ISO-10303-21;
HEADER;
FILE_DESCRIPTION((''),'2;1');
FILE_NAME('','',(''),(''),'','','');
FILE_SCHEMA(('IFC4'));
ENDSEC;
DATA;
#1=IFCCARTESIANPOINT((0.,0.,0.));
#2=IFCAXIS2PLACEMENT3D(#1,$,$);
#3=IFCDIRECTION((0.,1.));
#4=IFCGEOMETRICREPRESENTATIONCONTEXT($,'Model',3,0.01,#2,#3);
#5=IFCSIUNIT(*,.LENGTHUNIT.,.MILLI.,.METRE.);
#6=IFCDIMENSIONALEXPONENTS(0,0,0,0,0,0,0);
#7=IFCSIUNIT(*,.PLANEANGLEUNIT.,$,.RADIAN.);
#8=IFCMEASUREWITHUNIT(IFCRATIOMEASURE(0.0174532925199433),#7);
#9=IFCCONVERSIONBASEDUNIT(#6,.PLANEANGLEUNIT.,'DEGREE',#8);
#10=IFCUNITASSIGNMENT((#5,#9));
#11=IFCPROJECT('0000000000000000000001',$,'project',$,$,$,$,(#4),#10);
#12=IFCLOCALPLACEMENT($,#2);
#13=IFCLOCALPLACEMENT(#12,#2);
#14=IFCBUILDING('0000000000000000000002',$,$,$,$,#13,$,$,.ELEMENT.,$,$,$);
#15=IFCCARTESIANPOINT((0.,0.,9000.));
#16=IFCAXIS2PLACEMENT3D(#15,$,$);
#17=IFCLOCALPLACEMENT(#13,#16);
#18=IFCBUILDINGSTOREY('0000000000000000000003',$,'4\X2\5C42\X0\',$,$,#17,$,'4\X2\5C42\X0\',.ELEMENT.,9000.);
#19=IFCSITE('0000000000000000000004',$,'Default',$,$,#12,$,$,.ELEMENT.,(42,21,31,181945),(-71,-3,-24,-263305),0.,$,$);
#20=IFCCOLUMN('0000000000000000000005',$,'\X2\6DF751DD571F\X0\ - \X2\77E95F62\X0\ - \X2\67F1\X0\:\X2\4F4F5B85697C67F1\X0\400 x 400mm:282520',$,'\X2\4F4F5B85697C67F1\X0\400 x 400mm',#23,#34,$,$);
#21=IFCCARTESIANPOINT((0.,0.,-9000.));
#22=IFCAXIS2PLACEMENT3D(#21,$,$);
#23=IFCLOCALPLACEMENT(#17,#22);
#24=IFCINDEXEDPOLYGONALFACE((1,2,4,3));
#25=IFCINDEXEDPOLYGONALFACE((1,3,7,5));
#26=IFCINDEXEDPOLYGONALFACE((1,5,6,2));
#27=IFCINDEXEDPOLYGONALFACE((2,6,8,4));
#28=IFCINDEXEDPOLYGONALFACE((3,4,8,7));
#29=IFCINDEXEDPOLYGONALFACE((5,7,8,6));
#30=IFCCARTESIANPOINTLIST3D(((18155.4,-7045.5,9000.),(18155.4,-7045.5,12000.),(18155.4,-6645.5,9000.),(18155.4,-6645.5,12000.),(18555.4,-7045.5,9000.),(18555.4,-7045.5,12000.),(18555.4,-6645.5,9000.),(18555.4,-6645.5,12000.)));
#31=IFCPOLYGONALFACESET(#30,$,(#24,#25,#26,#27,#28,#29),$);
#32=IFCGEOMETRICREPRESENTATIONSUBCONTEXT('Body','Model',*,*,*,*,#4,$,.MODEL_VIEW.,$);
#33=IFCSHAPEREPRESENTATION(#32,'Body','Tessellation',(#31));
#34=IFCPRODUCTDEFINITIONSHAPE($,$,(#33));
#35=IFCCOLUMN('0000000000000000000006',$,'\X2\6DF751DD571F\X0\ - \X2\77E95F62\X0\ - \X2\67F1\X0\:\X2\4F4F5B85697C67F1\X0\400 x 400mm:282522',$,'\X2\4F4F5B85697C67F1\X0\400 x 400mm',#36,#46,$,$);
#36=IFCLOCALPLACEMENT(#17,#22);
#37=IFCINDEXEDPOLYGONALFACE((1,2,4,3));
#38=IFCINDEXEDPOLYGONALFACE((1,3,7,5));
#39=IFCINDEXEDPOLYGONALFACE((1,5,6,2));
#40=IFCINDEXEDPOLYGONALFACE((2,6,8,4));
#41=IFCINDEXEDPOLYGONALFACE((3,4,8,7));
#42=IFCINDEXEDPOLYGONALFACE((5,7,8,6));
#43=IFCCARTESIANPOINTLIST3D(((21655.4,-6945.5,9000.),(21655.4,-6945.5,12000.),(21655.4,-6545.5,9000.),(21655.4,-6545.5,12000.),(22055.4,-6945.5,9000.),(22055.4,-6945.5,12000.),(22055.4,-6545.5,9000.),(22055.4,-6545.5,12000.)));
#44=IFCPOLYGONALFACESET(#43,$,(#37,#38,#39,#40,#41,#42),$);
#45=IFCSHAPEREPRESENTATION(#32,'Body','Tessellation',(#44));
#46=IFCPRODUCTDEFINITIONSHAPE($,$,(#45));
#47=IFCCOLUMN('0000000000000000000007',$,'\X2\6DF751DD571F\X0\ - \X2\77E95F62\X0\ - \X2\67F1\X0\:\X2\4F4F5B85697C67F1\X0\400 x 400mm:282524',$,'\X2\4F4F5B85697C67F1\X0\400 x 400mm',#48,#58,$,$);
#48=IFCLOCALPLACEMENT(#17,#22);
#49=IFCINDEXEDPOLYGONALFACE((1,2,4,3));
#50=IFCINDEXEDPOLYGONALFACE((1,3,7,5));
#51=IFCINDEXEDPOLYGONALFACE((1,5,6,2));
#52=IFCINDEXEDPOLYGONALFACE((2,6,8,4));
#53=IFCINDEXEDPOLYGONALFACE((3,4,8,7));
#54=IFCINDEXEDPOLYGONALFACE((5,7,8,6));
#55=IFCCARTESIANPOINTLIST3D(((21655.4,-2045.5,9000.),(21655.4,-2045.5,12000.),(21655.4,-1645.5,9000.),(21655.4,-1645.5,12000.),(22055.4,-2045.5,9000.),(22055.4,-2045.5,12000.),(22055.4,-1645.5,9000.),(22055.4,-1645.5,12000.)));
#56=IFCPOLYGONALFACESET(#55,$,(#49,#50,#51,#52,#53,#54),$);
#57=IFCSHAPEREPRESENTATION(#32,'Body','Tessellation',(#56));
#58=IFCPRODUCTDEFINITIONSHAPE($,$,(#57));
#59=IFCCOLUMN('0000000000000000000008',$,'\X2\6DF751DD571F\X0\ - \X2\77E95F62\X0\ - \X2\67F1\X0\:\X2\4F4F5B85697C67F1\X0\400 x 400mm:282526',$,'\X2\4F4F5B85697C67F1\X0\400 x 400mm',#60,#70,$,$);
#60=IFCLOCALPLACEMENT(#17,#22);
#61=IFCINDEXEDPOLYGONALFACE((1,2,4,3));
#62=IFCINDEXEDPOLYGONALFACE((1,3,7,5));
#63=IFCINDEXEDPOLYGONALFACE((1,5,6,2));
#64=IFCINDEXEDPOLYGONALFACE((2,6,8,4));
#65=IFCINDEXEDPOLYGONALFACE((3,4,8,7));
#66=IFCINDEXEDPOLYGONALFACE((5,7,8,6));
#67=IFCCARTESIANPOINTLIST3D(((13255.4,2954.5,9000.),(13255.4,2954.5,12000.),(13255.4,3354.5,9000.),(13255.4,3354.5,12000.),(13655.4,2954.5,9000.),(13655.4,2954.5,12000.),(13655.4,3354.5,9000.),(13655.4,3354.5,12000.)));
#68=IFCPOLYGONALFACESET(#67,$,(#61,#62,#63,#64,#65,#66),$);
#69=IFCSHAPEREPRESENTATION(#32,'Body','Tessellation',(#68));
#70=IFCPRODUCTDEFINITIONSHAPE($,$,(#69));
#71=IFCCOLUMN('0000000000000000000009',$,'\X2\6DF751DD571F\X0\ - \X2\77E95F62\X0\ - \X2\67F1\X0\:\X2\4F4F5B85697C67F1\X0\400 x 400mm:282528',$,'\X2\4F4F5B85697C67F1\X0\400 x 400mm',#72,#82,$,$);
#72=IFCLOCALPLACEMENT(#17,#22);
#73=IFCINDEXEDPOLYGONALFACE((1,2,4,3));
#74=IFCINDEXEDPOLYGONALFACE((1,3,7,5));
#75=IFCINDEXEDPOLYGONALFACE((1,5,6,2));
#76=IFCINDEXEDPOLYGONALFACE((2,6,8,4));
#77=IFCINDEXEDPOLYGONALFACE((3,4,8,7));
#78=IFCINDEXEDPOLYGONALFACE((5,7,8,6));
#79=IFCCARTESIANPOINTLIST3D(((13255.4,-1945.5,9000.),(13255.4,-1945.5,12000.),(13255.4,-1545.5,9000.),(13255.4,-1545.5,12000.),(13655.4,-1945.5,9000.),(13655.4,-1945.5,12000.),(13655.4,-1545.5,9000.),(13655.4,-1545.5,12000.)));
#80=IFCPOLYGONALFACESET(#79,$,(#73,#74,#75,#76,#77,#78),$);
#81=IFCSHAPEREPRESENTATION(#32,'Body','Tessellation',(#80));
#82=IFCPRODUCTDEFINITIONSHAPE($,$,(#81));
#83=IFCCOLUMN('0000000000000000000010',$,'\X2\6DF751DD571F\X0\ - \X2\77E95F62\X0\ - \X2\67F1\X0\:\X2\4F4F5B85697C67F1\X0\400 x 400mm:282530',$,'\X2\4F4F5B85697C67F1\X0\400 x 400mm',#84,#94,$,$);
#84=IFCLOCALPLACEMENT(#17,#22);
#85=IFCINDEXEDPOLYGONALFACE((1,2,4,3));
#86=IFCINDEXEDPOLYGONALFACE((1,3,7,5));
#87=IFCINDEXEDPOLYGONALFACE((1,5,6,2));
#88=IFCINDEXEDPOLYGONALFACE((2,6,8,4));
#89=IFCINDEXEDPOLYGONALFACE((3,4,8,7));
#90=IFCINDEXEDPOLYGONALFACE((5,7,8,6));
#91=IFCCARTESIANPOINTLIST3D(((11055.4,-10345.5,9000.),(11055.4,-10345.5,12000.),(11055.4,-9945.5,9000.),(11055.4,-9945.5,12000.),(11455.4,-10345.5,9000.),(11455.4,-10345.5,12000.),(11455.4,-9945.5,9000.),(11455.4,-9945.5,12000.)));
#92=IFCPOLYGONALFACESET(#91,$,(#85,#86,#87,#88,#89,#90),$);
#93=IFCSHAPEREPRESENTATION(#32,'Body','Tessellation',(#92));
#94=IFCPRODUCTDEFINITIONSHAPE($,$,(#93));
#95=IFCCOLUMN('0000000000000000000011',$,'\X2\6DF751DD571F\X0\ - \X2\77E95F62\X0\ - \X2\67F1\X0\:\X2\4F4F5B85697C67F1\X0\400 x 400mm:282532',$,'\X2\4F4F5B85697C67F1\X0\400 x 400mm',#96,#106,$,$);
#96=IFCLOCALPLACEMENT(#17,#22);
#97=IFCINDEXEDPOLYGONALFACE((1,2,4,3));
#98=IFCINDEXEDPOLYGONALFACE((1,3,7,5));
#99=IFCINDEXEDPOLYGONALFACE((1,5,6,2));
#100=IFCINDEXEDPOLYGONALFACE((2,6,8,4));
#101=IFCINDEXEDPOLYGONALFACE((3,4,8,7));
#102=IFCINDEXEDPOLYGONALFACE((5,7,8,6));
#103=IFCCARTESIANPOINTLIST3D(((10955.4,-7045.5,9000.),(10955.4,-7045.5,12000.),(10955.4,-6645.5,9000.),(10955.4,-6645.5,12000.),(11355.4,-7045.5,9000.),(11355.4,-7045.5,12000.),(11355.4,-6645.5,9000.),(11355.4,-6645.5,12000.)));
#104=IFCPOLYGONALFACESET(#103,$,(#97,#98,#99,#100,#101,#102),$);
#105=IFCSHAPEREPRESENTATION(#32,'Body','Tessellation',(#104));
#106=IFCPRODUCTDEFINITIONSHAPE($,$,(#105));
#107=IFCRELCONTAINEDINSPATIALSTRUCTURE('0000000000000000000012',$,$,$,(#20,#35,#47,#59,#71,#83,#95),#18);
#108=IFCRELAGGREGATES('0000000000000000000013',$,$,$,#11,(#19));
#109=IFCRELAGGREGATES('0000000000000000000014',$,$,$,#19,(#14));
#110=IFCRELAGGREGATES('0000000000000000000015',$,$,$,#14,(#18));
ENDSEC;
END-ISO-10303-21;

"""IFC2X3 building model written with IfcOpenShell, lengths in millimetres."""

from ifc_helpers import new_model, entity, si_unit, converted_unit, direction, frame, frame_2d, origin, origin_2d_with_axis, place, context, subcontext, project, spatial, rectangle, extrude, source, transform, mapped, element, save


model = new_model("IFC2X3")

# Units and contexts
model_context = context("Model", 3, precision=0.01, world=origin(), true_north=direction((0.0, 1.0)))
body_context = subcontext(model_context, "Body", "Model", "MODEL_VIEW")
ifc_project = project(units=[si_unit("LENGTHUNIT", "METRE", prefix="MILLI"), converted_unit("PLANEANGLEUNIT", "DEGREE", entity("IfcRatioMeasure", 0.0174532925199433), si_unit("PLANEANGLEUNIT", "RADIAN"), dimensions=[0, 0, 0, 0, 0, 0, 0])], contexts=[model_context])

# Site, building, storey
site_placement = place(None, origin())
site = spatial("IfcSite", under=ifc_project, at=site_placement, Name="Default", CompositionType="ELEMENT", RefLatitude=(42, 21, 31, 181945), RefLongitude=(-71, -3, -24, -263305), RefElevation=0.0)
building_placement = place(site_placement, origin())
building = spatial("IfcBuilding", under=site, at=building_placement, CompositionType="ELEMENT")
storey_placement = place(building_placement, frame((0.0, 0.0, 9000.0)))
storey = spatial("IfcBuildingStorey", under=building, at=storey_placement, Name="4层", LongName="4层", CompositionType="ELEMENT", Elevation=9000.0)

# Columns
shared_shape_1 = source(origin(), body_context, "Body", "SweptSolid", [
    extrude(rectangle(XDim=400.0, YDim=400.0, at=origin_2d_with_axis()), frame((18355.4, -6845.5, 9000.0), z_axis=(0.0, 0.0, 1.0), x_axis=(0.0, -1.0, 0.0)), (0.0, 0.0, 1.0), 3000.0),
])
column_1_placement = place(storey_placement, frame((0.0, 0.0, -9000.0)))
element("IfcColumn", 1, at=column_1_placement, inside=storey, Name="混凝土 - 矩形 - 柱:住宅楼柱400 x 400mm:282520", ObjectType="住宅楼柱400 x 400mm", context=body_context, shape_type="MappedRepresentation", body=[
    mapped(shared_shape_1, transform((0.0, 0.0, 0.0), scale=1.0)),
])
shared_shape_2 = source(origin(), body_context, "Body", "SweptSolid", [
    extrude(rectangle(XDim=400.0, YDim=400.0, at=frame_2d((0.0, 0.0), x_axis=(1.0, 0.0))), frame((21855.4, -6745.5, 9000.0), z_axis=(0.0, 0.0, 1.0), x_axis=(0.0, -1.0, 0.0)), (0.0, 0.0, 1.0), 3000.0),
])
column_2_placement = place(storey_placement, frame((0.0, 0.0, -9000.0)))
element("IfcColumn", 2, at=column_2_placement, inside=storey, Name="混凝土 - 矩形 - 柱:住宅楼柱400 x 400mm:282522", ObjectType="住宅楼柱400 x 400mm", context=body_context, shape_type="MappedRepresentation", body=[
    mapped(shared_shape_2, transform((0.0, 0.0, 0.0), scale=1.0)),
])
shared_shape_3 = source(origin(), body_context, "Body", "SweptSolid", [
    extrude(rectangle(XDim=400.0, YDim=400.0, at=frame_2d((0.0, 0.0), x_axis=(1.0, 0.0))), frame((21855.4, -1845.5, 9000.0), z_axis=(0.0, 0.0, 1.0), x_axis=(0.0, -1.0, 0.0)), (0.0, 0.0, 1.0), 3000.0),
])
column_3_placement = place(storey_placement, frame((0.0, 0.0, -9000.0)))
element("IfcColumn", 3, at=column_3_placement, inside=storey, Name="混凝土 - 矩形 - 柱:住宅楼柱400 x 400mm:282524", ObjectType="住宅楼柱400 x 400mm", context=body_context, shape_type="MappedRepresentation", body=[
    mapped(shared_shape_3, transform((0.0, 0.0, 0.0), scale=1.0)),
])
shared_shape_4 = source(origin(), body_context, "Body", "SweptSolid", [
    extrude(rectangle(XDim=400.0, YDim=400.0, at=origin_2d_with_axis()), frame((13455.4, 3154.5, 9000.0), z_axis=(0.0, 0.0, 1.0), x_axis=(0.0, -1.0, 0.0)), (0.0, 0.0, 1.0), 3000.0),
])
column_4_placement = place(storey_placement, frame((0.0, 0.0, -9000.0)))
element("IfcColumn", 4, at=column_4_placement, inside=storey, Name="混凝土 - 矩形 - 柱:住宅楼柱400 x 400mm:282526", ObjectType="住宅楼柱400 x 400mm", context=body_context, shape_type="MappedRepresentation", body=[
    mapped(shared_shape_4, transform((0.0, 0.0, 0.0), scale=1.0)),
])
shared_shape_5 = source(origin(), body_context, "Body", "SweptSolid", [
    extrude(rectangle(XDim=400.0, YDim=400.0, at=origin_2d_with_axis()), frame((13455.4, -1745.5, 9000.0), z_axis=(0.0, 0.0, 1.0), x_axis=(0.0, -1.0, 0.0)), (0.0, 0.0, 1.0), 3000.0),
])
column_5_placement = place(storey_placement, frame((0.0, 0.0, -9000.0)))
element("IfcColumn", 5, at=column_5_placement, inside=storey, Name="混凝土 - 矩形 - 柱:住宅楼柱400 x 400mm:282528", ObjectType="住宅楼柱400 x 400mm", context=body_context, shape_type="MappedRepresentation", body=[
    mapped(shared_shape_5, transform((0.0, 0.0, 0.0), scale=1.0)),
])
shared_shape_6 = source(origin(), body_context, "Body", "SweptSolid", [
    extrude(rectangle(XDim=400.0, YDim=400.0, at=origin_2d_with_axis()), frame((11255.4, -10145.5, 9000.0), z_axis=(0.0, 0.0, 1.0), x_axis=(0.0, -1.0, 0.0)), (0.0, 0.0, 1.0), 3000.0),
])
column_6_placement = place(storey_placement, frame((0.0, 0.0, -9000.0)))
element("IfcColumn", 6, at=column_6_placement, inside=storey, Name="混凝土 - 矩形 - 柱:住宅楼柱400 x 400mm:282530", ObjectType="住宅楼柱400 x 400mm", context=body_context, shape_type="MappedRepresentation", body=[
    mapped(shared_shape_6, transform((0.0, 0.0, 0.0), scale=1.0)),
])
shared_shape_7 = source(origin(), body_context, "Body", "SweptSolid", [
    extrude(rectangle(XDim=400.0, YDim=400.0, at=origin_2d_with_axis()), frame((11155.4, -6845.5, 9000.0), z_axis=(0.0, 0.0, 1.0), x_axis=(0.0, -1.0, 0.0)), (0.0, 0.0, 1.0), 3000.0),
])
column_7_placement = place(storey_placement, frame((0.0, 0.0, -9000.0)))
element("IfcColumn", 7, at=column_7_placement, inside=storey, Name="混凝土 - 矩形 - 柱:住宅楼柱400 x 400mm:282532", ObjectType="住宅楼柱400 x 400mm", context=body_context, shape_type="MappedRepresentation", body=[
    mapped(shared_shape_7, transform((0.0, 0.0, 0.0), scale=1.0)),
])

save(model, "model.ifc")
